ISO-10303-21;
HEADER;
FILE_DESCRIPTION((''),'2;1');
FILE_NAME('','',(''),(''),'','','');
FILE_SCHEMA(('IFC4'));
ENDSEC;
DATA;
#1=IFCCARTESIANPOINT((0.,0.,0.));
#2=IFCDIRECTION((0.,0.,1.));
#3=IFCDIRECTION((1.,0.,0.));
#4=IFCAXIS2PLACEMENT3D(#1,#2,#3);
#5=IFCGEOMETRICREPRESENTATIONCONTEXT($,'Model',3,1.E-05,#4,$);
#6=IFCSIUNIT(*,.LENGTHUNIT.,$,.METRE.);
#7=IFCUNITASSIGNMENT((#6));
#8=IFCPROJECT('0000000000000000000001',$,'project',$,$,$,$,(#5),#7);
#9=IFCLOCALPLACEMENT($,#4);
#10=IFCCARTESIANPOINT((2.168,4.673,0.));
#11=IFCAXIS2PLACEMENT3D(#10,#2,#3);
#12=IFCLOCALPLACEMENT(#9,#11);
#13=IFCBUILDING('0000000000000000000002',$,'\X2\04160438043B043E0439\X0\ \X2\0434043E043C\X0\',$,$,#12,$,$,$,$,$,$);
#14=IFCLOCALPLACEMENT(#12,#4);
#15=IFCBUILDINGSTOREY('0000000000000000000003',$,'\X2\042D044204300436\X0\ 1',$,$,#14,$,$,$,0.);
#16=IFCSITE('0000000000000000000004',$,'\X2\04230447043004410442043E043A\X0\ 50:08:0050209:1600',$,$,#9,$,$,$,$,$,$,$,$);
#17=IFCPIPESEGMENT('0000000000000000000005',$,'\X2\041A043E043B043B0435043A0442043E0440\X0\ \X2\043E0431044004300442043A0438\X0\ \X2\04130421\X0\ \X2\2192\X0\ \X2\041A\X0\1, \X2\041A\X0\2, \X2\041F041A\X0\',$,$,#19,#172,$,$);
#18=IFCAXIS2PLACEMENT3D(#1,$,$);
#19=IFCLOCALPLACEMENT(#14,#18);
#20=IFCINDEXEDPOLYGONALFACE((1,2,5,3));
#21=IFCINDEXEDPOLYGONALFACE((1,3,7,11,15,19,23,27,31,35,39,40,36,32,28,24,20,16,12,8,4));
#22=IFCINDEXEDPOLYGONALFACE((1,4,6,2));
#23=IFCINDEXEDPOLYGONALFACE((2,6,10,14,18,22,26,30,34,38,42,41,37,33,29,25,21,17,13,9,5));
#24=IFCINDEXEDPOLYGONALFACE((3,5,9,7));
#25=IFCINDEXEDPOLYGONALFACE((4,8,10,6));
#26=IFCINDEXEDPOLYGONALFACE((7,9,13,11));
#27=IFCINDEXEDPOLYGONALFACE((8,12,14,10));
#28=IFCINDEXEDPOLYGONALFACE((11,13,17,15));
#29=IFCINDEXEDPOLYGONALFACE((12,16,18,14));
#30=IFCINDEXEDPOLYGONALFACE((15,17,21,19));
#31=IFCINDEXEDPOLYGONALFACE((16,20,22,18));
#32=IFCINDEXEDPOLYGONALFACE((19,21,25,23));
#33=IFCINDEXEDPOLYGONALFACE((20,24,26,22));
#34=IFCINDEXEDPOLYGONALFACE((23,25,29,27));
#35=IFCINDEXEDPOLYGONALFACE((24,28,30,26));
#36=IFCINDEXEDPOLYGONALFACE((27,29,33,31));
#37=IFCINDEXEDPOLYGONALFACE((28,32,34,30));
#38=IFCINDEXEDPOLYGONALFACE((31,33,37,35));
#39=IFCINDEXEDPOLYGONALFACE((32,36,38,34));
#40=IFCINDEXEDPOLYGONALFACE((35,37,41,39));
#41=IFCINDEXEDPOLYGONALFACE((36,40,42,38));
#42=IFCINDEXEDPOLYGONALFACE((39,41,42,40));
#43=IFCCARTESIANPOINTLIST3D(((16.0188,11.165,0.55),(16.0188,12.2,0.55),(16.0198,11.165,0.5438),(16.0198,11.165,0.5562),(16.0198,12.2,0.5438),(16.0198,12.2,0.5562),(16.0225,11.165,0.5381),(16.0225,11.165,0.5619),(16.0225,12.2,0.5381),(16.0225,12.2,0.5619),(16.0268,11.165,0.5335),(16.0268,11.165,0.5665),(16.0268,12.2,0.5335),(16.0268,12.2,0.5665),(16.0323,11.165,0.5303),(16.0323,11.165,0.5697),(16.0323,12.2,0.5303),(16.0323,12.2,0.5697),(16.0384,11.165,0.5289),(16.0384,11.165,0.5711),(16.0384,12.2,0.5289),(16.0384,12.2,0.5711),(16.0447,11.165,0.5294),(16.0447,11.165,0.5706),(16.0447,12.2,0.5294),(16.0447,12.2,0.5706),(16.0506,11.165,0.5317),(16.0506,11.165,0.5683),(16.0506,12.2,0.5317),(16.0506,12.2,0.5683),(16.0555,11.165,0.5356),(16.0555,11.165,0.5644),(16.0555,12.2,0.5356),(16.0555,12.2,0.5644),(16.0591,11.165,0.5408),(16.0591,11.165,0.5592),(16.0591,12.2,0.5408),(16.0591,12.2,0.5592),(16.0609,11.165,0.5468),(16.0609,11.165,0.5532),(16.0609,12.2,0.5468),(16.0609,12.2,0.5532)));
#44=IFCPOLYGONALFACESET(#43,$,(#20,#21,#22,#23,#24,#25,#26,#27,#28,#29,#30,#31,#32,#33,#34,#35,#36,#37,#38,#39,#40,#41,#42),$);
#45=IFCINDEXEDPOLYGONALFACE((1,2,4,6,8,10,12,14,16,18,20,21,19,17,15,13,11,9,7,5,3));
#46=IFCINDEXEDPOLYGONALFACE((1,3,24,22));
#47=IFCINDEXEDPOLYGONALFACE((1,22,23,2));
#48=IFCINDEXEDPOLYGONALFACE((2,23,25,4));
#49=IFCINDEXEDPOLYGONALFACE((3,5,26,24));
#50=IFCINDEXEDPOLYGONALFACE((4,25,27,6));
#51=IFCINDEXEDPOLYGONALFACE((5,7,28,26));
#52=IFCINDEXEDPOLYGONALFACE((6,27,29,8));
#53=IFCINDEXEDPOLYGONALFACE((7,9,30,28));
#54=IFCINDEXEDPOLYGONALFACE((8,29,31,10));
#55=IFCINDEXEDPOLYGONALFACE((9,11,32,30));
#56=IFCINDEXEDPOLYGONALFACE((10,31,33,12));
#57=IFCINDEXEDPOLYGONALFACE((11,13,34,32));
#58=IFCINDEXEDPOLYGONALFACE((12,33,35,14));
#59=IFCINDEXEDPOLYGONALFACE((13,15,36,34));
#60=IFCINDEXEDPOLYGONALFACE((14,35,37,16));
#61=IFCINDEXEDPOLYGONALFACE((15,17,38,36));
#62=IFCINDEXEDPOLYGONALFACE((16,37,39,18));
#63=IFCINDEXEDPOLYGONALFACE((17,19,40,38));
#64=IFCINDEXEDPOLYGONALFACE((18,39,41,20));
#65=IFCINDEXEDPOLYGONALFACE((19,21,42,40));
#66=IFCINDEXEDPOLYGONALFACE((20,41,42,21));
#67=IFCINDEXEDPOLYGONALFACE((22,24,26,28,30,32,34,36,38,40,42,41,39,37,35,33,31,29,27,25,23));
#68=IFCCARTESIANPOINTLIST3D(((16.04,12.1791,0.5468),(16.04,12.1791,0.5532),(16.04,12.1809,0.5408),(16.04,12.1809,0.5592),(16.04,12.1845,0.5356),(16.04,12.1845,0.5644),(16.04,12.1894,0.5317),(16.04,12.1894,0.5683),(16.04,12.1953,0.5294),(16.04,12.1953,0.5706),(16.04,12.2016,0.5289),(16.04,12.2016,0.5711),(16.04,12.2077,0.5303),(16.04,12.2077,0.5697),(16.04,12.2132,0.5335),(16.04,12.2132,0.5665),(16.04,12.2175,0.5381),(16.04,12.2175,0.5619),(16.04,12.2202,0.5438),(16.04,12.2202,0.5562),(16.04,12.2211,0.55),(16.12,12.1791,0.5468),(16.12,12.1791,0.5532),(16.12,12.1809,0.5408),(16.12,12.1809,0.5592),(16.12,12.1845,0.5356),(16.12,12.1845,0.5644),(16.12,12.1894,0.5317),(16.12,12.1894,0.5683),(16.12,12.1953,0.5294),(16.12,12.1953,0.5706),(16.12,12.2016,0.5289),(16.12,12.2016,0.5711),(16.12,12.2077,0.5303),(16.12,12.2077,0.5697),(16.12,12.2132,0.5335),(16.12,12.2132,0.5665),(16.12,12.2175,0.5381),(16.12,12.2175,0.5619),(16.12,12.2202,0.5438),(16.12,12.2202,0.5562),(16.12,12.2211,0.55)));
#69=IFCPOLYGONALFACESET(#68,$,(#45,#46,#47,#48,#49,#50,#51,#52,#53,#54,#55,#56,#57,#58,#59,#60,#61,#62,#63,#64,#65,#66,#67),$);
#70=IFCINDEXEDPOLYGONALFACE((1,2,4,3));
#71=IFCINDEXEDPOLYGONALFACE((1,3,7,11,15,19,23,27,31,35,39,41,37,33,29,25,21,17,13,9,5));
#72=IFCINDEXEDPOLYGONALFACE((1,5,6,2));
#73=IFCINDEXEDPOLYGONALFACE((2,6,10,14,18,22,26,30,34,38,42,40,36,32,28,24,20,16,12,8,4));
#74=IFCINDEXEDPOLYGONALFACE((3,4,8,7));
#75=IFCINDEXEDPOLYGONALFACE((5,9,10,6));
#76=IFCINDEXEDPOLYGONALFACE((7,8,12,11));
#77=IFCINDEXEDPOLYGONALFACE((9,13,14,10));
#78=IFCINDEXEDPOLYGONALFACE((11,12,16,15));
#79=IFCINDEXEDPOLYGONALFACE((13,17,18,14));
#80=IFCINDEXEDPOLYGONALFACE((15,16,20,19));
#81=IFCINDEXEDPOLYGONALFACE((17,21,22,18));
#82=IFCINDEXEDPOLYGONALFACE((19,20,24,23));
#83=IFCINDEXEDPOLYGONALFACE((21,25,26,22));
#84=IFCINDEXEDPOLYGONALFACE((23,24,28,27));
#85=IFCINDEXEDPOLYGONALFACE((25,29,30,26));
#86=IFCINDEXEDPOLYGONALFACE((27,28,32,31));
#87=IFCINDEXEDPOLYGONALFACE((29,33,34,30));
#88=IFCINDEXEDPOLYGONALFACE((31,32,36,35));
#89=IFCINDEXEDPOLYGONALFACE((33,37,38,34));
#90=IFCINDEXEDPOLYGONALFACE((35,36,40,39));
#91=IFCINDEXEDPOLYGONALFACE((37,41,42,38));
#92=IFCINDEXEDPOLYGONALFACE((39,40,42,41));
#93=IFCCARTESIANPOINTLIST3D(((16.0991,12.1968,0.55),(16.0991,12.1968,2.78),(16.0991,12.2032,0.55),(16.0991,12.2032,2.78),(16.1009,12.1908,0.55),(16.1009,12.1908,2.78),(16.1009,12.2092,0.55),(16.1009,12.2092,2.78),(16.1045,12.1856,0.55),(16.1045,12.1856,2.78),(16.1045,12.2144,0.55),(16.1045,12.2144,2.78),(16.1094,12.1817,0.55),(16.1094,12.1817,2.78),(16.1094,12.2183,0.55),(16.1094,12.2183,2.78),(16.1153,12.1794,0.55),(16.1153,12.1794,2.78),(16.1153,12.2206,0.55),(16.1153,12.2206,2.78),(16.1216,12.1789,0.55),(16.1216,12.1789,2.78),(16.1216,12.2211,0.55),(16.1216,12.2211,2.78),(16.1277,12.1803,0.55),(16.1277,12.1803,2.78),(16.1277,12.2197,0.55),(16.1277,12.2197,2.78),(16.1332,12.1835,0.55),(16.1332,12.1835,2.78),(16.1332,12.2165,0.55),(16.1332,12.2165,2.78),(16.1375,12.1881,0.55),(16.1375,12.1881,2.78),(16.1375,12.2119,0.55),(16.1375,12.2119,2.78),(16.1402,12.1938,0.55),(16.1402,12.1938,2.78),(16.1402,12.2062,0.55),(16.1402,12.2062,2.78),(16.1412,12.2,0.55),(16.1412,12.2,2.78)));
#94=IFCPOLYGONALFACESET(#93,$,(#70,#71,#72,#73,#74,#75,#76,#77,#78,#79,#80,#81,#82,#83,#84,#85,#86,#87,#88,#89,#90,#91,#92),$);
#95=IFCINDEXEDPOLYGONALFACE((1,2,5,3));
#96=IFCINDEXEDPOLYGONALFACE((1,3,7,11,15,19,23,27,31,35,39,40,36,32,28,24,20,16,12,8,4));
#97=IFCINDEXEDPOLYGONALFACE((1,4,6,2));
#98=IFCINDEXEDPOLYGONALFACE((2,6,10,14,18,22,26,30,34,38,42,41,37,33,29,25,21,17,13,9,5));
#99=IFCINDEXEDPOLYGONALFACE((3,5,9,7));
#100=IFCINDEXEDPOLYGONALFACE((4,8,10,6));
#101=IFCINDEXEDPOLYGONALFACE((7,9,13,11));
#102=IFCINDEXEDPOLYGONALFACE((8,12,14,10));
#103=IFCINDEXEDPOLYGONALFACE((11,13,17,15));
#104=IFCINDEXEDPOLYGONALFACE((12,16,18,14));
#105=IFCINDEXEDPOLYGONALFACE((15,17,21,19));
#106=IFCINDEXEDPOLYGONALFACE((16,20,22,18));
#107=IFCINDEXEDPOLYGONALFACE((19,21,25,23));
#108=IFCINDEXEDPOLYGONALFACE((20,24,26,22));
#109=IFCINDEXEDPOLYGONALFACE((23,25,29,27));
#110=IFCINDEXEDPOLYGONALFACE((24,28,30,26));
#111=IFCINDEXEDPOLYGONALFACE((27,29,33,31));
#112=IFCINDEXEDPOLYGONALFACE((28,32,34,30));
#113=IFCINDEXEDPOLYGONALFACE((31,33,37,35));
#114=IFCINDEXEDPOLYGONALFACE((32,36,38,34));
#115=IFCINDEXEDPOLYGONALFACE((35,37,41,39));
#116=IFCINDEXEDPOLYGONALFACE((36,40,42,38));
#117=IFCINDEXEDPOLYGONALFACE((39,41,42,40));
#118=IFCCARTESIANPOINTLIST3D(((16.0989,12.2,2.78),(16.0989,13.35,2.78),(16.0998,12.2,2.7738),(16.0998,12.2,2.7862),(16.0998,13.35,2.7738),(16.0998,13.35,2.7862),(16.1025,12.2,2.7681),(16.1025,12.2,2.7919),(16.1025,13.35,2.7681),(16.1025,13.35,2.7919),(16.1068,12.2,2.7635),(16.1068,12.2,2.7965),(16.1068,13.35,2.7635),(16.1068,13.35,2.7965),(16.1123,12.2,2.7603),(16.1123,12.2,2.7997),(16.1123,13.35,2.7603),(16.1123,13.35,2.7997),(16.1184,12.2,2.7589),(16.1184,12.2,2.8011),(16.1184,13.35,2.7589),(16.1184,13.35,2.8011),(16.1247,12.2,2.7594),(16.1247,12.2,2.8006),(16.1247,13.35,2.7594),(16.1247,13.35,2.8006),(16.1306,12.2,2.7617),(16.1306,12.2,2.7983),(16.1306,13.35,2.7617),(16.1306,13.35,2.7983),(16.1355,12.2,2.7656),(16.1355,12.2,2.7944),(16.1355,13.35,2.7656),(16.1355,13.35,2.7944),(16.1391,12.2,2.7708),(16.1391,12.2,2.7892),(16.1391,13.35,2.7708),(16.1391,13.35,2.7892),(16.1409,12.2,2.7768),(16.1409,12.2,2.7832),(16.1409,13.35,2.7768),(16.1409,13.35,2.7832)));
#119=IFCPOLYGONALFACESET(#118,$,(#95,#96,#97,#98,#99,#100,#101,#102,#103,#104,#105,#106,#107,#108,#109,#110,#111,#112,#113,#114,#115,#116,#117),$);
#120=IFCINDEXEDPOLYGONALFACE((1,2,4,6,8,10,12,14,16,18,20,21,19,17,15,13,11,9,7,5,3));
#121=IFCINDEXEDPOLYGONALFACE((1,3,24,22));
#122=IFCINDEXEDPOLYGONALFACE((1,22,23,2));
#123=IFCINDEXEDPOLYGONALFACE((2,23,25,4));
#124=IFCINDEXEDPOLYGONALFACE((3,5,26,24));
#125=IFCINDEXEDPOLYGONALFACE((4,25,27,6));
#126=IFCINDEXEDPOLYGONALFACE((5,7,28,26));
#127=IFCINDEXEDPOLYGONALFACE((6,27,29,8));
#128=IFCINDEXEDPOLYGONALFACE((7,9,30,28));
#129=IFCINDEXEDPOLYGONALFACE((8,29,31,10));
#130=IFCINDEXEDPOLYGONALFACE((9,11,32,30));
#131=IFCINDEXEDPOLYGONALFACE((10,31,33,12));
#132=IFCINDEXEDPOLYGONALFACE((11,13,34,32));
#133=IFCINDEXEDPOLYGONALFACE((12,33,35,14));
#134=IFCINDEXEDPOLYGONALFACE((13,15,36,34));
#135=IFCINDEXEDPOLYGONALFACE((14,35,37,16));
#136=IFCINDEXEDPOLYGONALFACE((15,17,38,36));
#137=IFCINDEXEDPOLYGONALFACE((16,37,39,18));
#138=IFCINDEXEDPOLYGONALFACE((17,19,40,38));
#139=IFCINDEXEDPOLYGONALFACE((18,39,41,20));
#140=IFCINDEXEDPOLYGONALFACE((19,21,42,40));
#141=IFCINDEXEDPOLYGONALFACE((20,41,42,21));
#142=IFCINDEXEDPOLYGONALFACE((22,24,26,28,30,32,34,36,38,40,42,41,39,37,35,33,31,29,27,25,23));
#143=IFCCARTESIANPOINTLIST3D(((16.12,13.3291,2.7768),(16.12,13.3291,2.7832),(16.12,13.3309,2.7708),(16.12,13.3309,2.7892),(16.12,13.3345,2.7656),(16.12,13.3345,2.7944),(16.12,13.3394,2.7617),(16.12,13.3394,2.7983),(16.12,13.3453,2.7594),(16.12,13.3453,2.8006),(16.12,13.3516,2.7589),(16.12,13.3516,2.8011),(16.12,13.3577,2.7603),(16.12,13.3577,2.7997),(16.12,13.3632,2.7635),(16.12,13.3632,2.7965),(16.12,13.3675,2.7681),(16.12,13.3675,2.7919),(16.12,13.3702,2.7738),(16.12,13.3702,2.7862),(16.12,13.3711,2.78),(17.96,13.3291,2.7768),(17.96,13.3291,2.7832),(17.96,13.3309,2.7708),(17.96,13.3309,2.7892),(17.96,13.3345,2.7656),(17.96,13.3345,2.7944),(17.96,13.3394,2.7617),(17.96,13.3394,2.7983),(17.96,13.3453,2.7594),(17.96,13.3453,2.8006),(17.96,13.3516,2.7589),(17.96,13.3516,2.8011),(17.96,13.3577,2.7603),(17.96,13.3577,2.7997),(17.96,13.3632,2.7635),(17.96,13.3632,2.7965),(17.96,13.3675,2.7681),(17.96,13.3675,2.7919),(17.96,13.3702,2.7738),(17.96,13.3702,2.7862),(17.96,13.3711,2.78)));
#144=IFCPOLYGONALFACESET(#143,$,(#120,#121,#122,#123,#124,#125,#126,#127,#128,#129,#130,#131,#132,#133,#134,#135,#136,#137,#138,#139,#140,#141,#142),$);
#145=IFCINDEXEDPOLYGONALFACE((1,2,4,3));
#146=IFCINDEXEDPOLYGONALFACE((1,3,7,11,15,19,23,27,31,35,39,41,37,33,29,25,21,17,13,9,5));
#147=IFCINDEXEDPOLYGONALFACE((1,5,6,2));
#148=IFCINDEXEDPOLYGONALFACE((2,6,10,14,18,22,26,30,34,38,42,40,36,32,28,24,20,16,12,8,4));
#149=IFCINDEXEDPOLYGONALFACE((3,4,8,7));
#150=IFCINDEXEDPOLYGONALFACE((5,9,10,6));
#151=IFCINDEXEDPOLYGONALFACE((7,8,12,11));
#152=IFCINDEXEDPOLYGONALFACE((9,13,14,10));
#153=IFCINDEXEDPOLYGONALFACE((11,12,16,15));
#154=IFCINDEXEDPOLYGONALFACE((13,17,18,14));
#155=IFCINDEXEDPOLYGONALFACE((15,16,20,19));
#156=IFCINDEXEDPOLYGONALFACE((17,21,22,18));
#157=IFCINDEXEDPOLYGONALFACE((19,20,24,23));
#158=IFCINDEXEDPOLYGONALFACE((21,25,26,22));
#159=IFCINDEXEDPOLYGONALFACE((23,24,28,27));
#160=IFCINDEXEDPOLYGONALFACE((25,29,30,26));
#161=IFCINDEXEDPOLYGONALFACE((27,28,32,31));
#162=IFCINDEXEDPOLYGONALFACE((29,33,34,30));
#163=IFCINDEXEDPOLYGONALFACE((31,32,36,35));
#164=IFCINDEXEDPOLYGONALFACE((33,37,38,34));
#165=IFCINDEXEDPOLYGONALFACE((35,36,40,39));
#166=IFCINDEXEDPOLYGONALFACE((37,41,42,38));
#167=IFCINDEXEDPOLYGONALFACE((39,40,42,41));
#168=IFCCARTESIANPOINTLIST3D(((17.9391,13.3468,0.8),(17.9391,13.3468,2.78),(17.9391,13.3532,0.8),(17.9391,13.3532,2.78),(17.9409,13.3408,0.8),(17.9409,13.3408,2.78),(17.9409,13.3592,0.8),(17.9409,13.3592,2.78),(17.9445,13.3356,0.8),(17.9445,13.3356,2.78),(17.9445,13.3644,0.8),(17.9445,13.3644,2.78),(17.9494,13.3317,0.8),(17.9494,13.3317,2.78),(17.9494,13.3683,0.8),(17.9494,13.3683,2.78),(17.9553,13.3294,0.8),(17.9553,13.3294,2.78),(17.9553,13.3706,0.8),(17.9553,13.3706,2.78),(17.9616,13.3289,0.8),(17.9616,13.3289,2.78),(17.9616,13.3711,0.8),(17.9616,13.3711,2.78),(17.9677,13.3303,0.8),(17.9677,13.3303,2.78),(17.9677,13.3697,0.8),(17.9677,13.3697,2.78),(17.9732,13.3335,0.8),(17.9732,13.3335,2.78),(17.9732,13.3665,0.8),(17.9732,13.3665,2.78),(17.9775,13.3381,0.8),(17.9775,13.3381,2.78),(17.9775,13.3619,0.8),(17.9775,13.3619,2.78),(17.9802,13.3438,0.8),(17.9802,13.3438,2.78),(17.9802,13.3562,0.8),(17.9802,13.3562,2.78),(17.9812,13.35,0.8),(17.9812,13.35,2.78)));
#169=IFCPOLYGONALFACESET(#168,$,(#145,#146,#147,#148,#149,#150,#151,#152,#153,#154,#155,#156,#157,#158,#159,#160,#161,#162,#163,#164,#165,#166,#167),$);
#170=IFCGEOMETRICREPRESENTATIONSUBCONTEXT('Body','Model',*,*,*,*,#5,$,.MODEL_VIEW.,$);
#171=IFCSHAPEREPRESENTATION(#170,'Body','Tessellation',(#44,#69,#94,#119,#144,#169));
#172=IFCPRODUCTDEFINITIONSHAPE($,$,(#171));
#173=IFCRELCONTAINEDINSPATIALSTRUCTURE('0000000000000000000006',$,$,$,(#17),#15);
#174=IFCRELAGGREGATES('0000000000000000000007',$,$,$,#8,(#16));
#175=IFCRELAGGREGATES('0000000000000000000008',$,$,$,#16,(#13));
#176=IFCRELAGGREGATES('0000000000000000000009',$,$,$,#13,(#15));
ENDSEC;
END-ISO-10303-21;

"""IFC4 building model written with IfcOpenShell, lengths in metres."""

from ifc_helpers import new_model, si_unit, frame, origin_with_axes, origin_2d, place, context, subcontext, project, spatial, circle, extrude, element, save


model = new_model("IFC4")

# Units and contexts
model_context = context("Model", 3, precision=1e-05, world=origin_with_axes())
body_context = subcontext(model_context, "Body", "Model", "MODEL_VIEW")
ifc_project = project(units=[si_unit("LENGTHUNIT", "METRE")], contexts=[model_context])

# Site, building, storey
site_placement = place(None, origin_with_axes())
site = spatial("IfcSite", under=ifc_project, at=site_placement, Name="Участок 50:08:0050209:1600")
building_placement = place(site_placement, frame((2.168, 4.673, 0.0), z_axis=(0.0, 0.0, 1.0), x_axis=(1.0, 0.0, 0.0)))
building = spatial("IfcBuilding", under=site, at=building_placement, Name="Жилой дом")
storey_placement = place(building_placement, origin_with_axes())
storey = spatial("IfcBuildingStorey", under=building, at=storey_placement, Name="Этаж 1", Elevation=0.0)

# Pipe segment
pipe_segment_1_placement = place(storey_placement, origin_with_axes())
element("IfcPipeSegment", 1, at=pipe_segment_1_placement, inside=storey, Name="Коллектор обратки ГС → К1, К2, ПК", context=body_context, shape_type="SweptSolid", body=[
    extrude(circle(Radius=0.0211, at=origin_2d()), frame((16.04, 11.165, 0.55), z_axis=(0.0, 1.0, 0.0), x_axis=(-1.0, 0.0, 0.0)), (0.0, 0.0, 1.0), 1.035),
    extrude(circle(Radius=0.0211, at=origin_2d()), frame((16.04, 12.2, 0.55), z_axis=(1.0, 0.0, 0.0), x_axis=(0.0, 1.0, 0.0)), (0.0, 0.0, 1.0), 0.08),
    extrude(circle(Radius=0.0211, at=origin_2d()), frame((16.12, 12.2, 0.55), z_axis=(0.0, 0.0, 1.0), x_axis=(1.0, 0.0, 0.0)), (0.0, 0.0, 1.0), 2.23),
    extrude(circle(Radius=0.0211, at=origin_2d()), frame((16.12, 12.2, 2.78), z_axis=(0.0, 1.0, 0.0), x_axis=(-1.0, 0.0, 0.0)), (0.0, 0.0, 1.0), 1.15),
    extrude(circle(Radius=0.0211, at=origin_2d()), frame((16.12, 13.35, 2.78), z_axis=(1.0, 0.0, 0.0), x_axis=(0.0, 1.0, 0.0)), (0.0, 0.0, 1.0), 1.84),
    extrude(circle(Radius=0.0211, at=origin_2d()), frame((17.96, 13.35, 2.78), z_axis=(0.0, 0.0, -1.0), x_axis=(1.0, 0.0, 0.0)), (0.0, 0.0, 1.0), 1.98),
])

save(model, "model.ifc")
